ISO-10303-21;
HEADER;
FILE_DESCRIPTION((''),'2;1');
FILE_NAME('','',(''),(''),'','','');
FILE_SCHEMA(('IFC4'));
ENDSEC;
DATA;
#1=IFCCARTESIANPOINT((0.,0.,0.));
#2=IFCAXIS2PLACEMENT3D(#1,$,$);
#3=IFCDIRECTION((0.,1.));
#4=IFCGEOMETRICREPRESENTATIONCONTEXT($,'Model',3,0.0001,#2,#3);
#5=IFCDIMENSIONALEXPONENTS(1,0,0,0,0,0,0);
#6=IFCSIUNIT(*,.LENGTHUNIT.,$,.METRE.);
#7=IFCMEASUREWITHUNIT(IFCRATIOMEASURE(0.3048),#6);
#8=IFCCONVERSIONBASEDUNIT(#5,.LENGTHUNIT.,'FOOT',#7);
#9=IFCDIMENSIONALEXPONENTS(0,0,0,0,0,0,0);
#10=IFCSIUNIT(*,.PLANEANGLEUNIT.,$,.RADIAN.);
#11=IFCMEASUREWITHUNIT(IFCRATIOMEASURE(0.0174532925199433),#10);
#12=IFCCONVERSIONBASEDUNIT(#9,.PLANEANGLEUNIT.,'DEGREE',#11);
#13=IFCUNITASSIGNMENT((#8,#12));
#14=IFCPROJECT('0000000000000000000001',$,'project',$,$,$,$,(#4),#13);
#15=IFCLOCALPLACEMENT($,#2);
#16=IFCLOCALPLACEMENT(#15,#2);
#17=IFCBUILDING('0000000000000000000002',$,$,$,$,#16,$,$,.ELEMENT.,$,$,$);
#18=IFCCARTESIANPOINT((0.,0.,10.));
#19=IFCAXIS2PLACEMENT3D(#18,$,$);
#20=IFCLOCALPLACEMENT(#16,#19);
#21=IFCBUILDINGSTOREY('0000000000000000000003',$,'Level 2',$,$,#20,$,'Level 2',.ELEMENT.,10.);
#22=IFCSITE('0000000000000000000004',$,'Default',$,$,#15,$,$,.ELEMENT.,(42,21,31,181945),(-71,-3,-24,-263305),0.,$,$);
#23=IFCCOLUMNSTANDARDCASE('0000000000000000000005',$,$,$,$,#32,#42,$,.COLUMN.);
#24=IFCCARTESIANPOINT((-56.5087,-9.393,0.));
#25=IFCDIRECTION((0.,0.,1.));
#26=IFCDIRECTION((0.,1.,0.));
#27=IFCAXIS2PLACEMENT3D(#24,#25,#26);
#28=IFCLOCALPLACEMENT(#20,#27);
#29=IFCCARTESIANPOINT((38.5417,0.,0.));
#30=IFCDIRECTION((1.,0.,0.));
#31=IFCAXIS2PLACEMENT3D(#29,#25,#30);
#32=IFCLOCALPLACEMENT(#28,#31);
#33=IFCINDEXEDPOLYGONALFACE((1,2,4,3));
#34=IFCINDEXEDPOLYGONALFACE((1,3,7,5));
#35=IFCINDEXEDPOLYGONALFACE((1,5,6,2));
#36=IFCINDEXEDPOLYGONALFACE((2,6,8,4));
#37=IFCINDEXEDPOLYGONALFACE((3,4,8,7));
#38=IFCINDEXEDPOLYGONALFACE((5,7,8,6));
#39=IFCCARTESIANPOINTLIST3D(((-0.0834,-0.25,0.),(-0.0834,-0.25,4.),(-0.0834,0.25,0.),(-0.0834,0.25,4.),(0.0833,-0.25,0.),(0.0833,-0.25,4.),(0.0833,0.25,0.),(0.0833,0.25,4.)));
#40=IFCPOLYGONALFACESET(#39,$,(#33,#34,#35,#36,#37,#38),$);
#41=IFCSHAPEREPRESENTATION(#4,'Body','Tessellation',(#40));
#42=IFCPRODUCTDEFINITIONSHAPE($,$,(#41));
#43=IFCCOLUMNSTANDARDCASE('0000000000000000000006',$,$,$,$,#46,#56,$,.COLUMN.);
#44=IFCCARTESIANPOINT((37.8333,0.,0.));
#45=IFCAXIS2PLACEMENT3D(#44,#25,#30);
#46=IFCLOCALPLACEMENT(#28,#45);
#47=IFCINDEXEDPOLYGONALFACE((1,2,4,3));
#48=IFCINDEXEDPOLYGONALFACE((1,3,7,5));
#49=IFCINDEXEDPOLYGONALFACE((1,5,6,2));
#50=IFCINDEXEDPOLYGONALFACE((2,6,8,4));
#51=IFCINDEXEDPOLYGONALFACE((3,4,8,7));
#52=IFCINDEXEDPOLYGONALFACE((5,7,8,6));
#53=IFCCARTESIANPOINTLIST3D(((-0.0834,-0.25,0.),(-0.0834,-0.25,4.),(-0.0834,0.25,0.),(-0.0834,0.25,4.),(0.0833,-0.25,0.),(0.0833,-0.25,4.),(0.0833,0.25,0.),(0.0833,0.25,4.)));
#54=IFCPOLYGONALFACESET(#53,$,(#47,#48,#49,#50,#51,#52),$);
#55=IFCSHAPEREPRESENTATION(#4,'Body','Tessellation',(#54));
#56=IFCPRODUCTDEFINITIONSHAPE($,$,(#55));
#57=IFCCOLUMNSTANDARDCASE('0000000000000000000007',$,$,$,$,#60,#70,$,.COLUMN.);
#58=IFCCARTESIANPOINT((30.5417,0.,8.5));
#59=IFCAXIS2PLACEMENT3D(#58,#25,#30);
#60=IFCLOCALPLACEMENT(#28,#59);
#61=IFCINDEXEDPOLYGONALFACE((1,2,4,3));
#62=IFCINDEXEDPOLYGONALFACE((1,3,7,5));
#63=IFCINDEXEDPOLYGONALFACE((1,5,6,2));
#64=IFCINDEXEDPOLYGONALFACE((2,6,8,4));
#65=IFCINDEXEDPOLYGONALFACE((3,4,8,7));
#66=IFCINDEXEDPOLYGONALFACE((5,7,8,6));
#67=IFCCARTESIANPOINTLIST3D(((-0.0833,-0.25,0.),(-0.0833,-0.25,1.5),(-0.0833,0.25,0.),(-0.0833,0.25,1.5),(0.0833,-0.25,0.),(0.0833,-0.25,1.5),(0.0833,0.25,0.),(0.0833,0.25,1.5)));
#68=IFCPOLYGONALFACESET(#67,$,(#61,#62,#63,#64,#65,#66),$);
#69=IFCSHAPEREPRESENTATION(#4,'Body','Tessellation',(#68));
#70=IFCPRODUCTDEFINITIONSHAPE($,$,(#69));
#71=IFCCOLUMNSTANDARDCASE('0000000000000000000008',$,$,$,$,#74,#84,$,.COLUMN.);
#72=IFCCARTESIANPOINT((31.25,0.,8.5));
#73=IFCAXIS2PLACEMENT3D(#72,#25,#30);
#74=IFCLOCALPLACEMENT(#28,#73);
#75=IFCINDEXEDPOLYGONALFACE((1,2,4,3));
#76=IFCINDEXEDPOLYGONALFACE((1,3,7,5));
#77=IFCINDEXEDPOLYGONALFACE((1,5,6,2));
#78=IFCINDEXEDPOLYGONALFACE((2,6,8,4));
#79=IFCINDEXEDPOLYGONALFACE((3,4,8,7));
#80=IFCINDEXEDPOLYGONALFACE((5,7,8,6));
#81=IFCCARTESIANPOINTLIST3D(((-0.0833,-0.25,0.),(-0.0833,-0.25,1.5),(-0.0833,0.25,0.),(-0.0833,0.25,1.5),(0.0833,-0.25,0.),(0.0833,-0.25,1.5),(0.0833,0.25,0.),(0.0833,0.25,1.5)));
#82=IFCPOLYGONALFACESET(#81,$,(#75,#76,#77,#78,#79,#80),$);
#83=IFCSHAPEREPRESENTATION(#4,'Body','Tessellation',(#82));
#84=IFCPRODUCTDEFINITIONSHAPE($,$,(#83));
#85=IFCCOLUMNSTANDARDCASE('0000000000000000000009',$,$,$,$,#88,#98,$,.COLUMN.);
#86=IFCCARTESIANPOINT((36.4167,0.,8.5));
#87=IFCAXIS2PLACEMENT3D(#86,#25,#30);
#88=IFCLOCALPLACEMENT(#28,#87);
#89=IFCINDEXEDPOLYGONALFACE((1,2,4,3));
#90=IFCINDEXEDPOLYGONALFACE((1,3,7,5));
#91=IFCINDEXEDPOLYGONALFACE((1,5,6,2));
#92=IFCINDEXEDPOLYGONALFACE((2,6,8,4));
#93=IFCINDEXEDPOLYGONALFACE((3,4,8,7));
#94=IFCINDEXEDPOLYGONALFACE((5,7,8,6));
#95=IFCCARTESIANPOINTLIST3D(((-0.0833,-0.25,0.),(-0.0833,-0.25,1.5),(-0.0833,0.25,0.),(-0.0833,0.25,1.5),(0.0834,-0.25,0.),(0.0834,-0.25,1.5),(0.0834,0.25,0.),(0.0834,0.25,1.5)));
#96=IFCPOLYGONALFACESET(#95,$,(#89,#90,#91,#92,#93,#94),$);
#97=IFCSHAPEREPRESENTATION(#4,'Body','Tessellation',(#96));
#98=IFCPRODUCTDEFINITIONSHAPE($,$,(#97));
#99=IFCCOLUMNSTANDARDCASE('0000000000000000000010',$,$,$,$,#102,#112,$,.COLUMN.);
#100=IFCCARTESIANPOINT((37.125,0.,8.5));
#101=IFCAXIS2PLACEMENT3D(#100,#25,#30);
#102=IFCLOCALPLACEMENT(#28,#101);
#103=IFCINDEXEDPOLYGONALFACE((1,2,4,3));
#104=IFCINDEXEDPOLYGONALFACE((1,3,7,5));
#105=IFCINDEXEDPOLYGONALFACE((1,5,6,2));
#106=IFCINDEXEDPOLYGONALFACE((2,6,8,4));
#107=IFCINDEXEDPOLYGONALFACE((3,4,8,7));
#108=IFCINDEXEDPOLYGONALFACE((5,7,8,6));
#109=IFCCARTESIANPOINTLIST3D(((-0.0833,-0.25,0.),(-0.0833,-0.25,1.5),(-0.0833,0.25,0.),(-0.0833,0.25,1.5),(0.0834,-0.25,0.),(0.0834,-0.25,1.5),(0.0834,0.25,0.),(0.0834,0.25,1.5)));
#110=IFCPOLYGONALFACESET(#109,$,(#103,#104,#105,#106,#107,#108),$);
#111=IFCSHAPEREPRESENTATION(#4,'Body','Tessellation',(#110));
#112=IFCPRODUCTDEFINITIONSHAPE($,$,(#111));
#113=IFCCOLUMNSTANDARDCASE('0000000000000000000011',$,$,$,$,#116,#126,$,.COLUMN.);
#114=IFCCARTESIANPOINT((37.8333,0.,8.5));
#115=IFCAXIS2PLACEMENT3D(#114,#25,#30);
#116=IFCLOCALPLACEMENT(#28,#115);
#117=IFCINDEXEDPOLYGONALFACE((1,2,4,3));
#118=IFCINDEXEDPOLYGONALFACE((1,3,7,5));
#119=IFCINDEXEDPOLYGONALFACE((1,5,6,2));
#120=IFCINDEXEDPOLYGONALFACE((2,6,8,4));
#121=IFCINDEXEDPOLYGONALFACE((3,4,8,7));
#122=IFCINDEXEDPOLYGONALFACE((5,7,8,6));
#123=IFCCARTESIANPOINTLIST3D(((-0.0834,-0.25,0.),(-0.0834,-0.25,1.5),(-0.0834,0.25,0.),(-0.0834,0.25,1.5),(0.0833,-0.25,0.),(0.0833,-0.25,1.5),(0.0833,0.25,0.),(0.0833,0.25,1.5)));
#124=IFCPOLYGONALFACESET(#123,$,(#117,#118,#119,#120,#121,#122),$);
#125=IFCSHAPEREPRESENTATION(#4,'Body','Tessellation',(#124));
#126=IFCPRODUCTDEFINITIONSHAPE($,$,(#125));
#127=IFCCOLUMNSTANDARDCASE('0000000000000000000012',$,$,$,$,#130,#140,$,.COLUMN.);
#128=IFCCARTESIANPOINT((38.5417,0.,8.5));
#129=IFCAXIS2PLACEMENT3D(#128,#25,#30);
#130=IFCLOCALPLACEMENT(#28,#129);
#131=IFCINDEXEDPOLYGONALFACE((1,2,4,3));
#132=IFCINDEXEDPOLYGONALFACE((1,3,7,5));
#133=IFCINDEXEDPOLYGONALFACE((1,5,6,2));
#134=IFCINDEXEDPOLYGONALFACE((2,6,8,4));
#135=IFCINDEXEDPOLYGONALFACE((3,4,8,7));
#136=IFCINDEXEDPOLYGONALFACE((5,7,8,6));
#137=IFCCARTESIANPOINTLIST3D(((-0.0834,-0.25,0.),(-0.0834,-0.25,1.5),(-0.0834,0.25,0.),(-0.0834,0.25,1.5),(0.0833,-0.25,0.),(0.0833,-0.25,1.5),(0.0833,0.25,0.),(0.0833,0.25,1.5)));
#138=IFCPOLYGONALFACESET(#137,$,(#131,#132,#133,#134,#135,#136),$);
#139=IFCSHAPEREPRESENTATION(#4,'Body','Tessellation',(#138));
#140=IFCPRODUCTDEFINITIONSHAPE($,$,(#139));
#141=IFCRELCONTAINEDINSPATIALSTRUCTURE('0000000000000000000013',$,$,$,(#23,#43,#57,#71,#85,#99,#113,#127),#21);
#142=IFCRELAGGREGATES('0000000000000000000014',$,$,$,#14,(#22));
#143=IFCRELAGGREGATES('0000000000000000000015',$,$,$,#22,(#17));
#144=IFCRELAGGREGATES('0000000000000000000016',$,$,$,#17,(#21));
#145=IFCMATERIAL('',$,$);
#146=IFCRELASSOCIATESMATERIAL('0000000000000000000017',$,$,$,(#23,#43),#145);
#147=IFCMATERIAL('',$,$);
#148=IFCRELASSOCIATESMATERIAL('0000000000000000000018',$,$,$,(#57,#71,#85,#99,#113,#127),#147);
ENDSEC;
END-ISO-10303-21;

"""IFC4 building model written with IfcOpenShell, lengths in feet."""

from ifc_helpers import new_model, entity, si_unit, converted_unit, direction, frame, origin, place, context, project, spatial, rectangle, extrude, material, element, save


model = new_model("IFC4")

# Units and contexts
model_context = context("Model", 3, precision=0.0001, world=origin(), true_north=direction((0.0, 1.0)))
ifc_project = project(units=[converted_unit("LENGTHUNIT", "FOOT", entity("IfcRatioMeasure", 0.3048), si_unit("LENGTHUNIT", "METRE"), dimensions=[1, 0, 0, 0, 0, 0, 0]), converted_unit("PLANEANGLEUNIT", "DEGREE", entity("IfcRatioMeasure", 0.0174532925199433), si_unit("PLANEANGLEUNIT", "RADIAN"), dimensions=[0, 0, 0, 0, 0, 0, 0])], contexts=[model_context])

# Site, building, storey
site_placement = place(None, origin())
site = spatial("IfcSite", under=ifc_project, at=site_placement, Name="Default", CompositionType="ELEMENT", RefLatitude=(42, 21, 31, 181945), RefLongitude=(-71, -3, -24, -263305), RefElevation=0.0)
building_placement = place(site_placement, origin())
building = spatial("IfcBuilding", under=site, at=building_placement, CompositionType="ELEMENT")
storey_placement = place(building_placement, frame((0.0, 0.0, 10.0)))
storey = spatial("IfcBuildingStorey", under=building, at=storey_placement, Name="Level 2", LongName="Level 2", CompositionType="ELEMENT", Elevation=10.0)

# Columns
ifc_material_1 = material(Name="")
placement = place(storey_placement, frame((-56.5087, -9.393, 0.0), z_axis=(0.0, 0.0, 1.0), x_axis=(0.0, 1.0, 0.0)))
for number, where, z_axis, x_axis in (
    (1, (38.5417, 0.0, 0.0), (0.0, 0.0, 1.0), (1.0, 0.0, 0.0)),
    (2, (37.8333, 0.0, 0.0), (0.0, 0.0, 1.0), (1.0, 0.0, 0.0)),
):
    element("IfcColumnStandardCase", number, at=place(placement, frame(where, z_axis=z_axis, x_axis=x_axis)), inside=storey, material=ifc_material_1, PredefinedType="COLUMN", context=model_context, shape_type="SweptSolid", body=[
        extrude(rectangle(XDim=0.1667, YDim=0.5), origin(), (0.0, 0.0, 1.0), 4.0),
    ])
ifc_material_2 = material(Name="")
for number, where, z_axis, x_axis in (
    (3, (30.5417, 0.0, 8.5), (0.0, 0.0, 1.0), (1.0, 0.0, 0.0)),
    (4, (31.25, 0.0, 8.5), (0.0, 0.0, 1.0), (1.0, 0.0, 0.0)),
    (5, (36.4167, 0.0, 8.5), (0.0, 0.0, 1.0), (1.0, 0.0, 0.0)),
    (6, (37.125, 0.0, 8.5), (0.0, 0.0, 1.0), (1.0, 0.0, 0.0)),
    (7, (37.8333, 0.0, 8.5), (0.0, 0.0, 1.0), (1.0, 0.0, 0.0)),
    (8, (38.5417, 0.0, 8.5), (0.0, 0.0, 1.0), (1.0, 0.0, 0.0)),
):
    element("IfcColumnStandardCase", number, at=place(placement, frame(where, z_axis=z_axis, x_axis=x_axis)), inside=storey, material=ifc_material_2, PredefinedType="COLUMN", context=model_context, shape_type="SweptSolid", body=[
        extrude(rectangle(XDim=0.1667, YDim=0.5), origin(), (0.0, 0.0, 1.0), 1.5),
    ])

save(model, "model.ifc")
